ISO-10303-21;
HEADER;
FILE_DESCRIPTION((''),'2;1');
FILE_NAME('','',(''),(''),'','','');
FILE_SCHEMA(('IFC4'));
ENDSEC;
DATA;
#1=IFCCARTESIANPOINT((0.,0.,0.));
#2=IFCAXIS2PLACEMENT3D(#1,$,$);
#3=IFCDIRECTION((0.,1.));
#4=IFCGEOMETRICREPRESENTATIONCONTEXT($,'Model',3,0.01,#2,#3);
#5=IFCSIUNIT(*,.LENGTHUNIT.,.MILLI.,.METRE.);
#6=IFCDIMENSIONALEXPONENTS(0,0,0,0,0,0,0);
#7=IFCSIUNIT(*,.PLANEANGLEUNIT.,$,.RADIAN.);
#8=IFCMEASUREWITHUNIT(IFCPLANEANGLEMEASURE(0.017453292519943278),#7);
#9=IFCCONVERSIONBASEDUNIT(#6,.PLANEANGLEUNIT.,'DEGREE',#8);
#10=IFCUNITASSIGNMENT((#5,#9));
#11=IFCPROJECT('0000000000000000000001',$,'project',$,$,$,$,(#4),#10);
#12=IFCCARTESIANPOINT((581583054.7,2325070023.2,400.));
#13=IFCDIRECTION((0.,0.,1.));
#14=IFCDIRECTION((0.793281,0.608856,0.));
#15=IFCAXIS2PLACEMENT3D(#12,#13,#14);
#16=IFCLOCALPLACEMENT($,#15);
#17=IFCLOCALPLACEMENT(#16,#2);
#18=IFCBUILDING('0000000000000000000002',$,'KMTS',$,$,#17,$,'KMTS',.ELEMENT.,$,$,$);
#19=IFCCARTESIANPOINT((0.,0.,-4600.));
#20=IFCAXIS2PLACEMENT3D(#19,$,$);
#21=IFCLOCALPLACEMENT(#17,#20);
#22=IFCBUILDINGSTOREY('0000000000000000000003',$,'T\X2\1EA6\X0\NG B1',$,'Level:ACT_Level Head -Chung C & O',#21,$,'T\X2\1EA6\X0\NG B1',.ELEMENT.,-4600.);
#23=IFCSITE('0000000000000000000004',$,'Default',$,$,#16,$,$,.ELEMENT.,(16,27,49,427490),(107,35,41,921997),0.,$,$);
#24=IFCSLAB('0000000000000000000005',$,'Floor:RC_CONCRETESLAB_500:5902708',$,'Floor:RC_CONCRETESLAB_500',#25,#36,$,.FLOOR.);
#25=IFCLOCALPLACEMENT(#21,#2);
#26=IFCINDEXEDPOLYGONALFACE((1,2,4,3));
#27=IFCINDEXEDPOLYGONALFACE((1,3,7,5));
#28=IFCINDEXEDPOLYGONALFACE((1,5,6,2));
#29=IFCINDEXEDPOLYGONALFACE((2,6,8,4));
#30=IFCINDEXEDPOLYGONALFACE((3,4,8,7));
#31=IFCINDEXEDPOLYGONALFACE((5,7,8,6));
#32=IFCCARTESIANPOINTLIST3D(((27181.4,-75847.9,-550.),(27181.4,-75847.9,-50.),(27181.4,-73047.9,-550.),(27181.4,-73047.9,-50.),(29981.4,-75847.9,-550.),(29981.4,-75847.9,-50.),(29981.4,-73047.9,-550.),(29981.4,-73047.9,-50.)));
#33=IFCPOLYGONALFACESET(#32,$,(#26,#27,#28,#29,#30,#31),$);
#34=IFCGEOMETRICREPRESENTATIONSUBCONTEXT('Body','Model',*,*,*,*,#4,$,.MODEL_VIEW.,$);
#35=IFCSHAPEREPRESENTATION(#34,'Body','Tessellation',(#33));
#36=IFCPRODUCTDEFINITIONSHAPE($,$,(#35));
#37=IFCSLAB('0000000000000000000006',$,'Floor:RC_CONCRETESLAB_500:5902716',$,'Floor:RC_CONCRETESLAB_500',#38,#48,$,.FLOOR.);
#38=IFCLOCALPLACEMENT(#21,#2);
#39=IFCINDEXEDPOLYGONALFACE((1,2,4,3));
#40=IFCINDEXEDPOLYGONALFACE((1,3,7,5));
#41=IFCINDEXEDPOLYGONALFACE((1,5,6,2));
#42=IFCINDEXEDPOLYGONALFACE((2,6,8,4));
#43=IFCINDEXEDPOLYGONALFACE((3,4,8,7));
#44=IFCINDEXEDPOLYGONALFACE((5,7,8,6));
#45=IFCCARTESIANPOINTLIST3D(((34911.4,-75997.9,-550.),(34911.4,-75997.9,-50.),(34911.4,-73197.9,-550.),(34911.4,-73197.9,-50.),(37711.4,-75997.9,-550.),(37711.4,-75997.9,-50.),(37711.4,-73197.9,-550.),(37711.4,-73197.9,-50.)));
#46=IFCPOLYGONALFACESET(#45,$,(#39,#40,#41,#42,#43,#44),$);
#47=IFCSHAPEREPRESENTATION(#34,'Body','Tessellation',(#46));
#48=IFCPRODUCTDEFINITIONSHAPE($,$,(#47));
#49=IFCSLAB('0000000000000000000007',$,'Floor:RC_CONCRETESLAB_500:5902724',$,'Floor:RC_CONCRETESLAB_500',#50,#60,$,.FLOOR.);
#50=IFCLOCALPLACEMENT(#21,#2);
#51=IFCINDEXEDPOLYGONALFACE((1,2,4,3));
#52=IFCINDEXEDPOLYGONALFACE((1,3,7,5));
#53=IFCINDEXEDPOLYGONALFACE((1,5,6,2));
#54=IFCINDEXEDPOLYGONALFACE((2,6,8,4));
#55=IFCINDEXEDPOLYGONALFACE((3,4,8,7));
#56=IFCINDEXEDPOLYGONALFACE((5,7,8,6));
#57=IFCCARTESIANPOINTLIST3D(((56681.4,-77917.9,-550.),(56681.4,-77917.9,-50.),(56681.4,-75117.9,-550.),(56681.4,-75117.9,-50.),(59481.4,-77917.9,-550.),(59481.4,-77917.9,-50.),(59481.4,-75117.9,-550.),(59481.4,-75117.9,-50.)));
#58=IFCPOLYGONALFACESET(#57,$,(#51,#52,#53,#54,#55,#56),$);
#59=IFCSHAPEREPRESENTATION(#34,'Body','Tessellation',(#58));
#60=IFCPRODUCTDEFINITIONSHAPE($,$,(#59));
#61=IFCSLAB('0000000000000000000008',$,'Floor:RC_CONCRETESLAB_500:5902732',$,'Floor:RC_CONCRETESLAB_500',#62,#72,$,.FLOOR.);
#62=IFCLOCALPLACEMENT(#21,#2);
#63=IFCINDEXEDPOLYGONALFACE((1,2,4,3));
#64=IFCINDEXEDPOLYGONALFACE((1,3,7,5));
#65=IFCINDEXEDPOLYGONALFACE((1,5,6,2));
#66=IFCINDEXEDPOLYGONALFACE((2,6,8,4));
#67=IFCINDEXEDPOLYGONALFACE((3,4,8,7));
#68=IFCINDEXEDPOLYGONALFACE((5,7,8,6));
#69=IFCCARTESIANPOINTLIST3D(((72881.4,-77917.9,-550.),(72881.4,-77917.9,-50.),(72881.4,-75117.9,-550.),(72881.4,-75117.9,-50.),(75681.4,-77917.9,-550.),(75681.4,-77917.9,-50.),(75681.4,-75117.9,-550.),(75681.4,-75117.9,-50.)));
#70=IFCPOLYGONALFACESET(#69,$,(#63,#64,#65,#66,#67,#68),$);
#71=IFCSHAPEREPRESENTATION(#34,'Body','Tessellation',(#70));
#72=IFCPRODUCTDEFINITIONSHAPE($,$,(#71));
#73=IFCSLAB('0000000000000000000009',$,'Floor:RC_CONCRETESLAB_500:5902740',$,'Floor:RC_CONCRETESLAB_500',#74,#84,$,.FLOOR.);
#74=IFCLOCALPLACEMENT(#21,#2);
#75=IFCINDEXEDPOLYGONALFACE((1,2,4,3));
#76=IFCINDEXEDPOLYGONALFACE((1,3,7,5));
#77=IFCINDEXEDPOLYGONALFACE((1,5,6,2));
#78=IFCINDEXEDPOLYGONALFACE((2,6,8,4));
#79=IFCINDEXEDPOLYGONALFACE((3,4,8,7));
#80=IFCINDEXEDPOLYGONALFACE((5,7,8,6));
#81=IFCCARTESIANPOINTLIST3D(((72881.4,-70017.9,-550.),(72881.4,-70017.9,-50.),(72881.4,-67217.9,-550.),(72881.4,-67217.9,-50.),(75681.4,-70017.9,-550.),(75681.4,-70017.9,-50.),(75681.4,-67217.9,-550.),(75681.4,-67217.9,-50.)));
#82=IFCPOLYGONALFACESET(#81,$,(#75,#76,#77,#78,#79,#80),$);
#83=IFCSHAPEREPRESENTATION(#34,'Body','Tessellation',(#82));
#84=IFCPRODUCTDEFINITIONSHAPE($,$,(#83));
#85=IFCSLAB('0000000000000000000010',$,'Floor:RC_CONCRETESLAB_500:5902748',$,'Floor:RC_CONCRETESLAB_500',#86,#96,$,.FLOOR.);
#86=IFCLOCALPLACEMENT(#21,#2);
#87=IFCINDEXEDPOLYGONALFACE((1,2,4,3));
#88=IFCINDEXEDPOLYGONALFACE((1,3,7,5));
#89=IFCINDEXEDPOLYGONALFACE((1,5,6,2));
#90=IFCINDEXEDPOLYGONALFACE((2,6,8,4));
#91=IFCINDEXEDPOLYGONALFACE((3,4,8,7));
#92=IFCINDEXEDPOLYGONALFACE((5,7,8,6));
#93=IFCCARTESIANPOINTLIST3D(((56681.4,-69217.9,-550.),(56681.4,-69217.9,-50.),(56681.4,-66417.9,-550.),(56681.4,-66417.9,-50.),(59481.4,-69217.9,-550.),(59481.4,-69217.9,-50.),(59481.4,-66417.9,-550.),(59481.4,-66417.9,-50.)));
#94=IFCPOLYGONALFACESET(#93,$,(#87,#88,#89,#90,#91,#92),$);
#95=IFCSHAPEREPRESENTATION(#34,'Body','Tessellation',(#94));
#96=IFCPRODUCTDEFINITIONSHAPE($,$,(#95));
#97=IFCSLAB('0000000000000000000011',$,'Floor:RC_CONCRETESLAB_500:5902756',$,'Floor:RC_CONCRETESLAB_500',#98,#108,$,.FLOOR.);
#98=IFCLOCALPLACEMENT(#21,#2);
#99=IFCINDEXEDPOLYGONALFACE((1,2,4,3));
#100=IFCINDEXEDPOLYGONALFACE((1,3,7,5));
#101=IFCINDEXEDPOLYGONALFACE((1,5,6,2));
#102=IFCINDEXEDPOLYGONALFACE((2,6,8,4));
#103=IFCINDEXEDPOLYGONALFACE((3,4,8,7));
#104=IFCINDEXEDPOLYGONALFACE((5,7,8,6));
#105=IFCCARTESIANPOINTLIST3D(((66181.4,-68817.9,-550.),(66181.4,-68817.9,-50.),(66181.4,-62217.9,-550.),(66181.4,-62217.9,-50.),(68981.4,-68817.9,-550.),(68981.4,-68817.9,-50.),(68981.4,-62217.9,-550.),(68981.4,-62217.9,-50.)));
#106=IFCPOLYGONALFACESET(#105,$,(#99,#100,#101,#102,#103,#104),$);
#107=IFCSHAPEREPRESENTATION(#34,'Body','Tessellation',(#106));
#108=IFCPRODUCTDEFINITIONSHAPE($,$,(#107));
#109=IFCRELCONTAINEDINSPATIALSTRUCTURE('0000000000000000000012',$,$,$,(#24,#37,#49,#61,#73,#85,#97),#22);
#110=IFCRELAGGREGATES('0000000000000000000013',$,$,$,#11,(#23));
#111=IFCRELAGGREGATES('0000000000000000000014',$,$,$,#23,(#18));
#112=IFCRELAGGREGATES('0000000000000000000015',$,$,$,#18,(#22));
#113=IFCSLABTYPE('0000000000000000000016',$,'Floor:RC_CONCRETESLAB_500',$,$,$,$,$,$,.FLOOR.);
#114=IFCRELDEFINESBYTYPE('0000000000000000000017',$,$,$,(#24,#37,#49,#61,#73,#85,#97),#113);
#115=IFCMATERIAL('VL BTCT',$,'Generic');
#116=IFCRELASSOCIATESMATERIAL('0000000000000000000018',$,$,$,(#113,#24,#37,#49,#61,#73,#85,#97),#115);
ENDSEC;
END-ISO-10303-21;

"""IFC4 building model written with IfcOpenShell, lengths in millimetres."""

from ifc_helpers import new_model, entity, si_unit, converted_unit, direction, frame, origin, place, context, subcontext, project, spatial, indexed_curve, outline, extrude, material, type_object, element, save


model = new_model("IFC4")

# Units and contexts
model_context = context("Model", 3, precision=0.01, world=origin(), true_north=direction((0.0, 1.0)))
body_context = subcontext(model_context, "Body", "Model", "MODEL_VIEW")
ifc_project = project(units=[si_unit("LENGTHUNIT", "METRE", prefix="MILLI"), converted_unit("PLANEANGLEUNIT", "DEGREE", entity("IfcPlaneAngleMeasure", 0.017453292519943278), si_unit("PLANEANGLEUNIT", "RADIAN"), dimensions=[0, 0, 0, 0, 0, 0, 0])], contexts=[model_context])

# Site, building, storey
site_placement = place(None, frame((581583054.7, 2325070023.2, 400.0), z_axis=(0.0, 0.0, 1.0), x_axis=(0.793281, 0.608856, 0.0)))
site = spatial("IfcSite", under=ifc_project, at=site_placement, Name="Default", CompositionType="ELEMENT", RefLatitude=(16, 27, 49, 427490), RefLongitude=(107, 35, 41, 921997), RefElevation=0.0)
building_placement = place(site_placement, origin())
building = spatial("IfcBuilding", under=site, at=building_placement, Name="KMTS", LongName="KMTS", CompositionType="ELEMENT")
storey_placement = place(building_placement, frame((0.0, 0.0, -4600.0)))
storey = spatial("IfcBuildingStorey", under=building, at=storey_placement, Name="TẦNG B1", ObjectType="Level:ACT_Level Head -Chung C & O", LongName="TẦNG B1", CompositionType="ELEMENT", Elevation=-4600.0)

# Slabs
ifc_material = material(Name="VL BTCT", Category="Generic")
slab_type = type_object("IfcSlabType", Name="Floor:RC_CONCRETESLAB_500", PredefinedType="FLOOR", material=ifc_material)
slab_1_placement = place(storey_placement, origin())
element("IfcSlab", 1, at=slab_1_placement, inside=storey, type_object=slab_type, material=ifc_material, Name="Floor:RC_CONCRETESLAB_500:5902708", ObjectType="Floor:RC_CONCRETESLAB_500", PredefinedType="FLOOR", context=body_context, shape_type="SweptSolid", body=[
    extrude(outline(indexed_curve([(-1400.0, -1400.0), (1400.0, -1400.0), (1400.0, 1400.0), (-1400.0, 1400.0), (-1400.0, -1400.0)], self_intersect=False)), frame((28581.4, -74447.9, -50.0), z_axis=(0.0, 0.0, -1.0), x_axis=(0.0, 1.0, 0.0)), (0.0, 0.0, 1.0), 500.0),
])
slab_2_placement = place(storey_placement, origin())
element("IfcSlab", 2, at=slab_2_placement, inside=storey, type_object=slab_type, material=ifc_material, Name="Floor:RC_CONCRETESLAB_500:5902716", ObjectType="Floor:RC_CONCRETESLAB_500", PredefinedType="FLOOR", context=body_context, shape_type="SweptSolid", body=[
    extrude(outline(indexed_curve([(-1400.0, -1400.0), (1400.0, -1400.0), (1400.0, 1400.0), (-1400.0, 1400.0), (-1400.0, -1400.0)], self_intersect=False)), frame((36311.4, -74597.9, -50.0), z_axis=(0.0, 0.0, -1.0), x_axis=(0.0, 1.0, 0.0)), (0.0, 0.0, 1.0), 500.0),
])
slab_3_placement = place(storey_placement, origin())
element("IfcSlab", 3, at=slab_3_placement, inside=storey, type_object=slab_type, material=ifc_material, Name="Floor:RC_CONCRETESLAB_500:5902724", ObjectType="Floor:RC_CONCRETESLAB_500", PredefinedType="FLOOR", context=body_context, shape_type="SweptSolid", body=[
    extrude(outline(indexed_curve([(-1400.0, -1400.0), (1400.0, -1400.0), (1400.0, 1400.0), (-1400.0, 1400.0), (-1400.0, -1400.0)], self_intersect=False)), frame((58081.4, -76517.9, -50.0), z_axis=(0.0, 0.0, -1.0), x_axis=(0.0, 1.0, 0.0)), (0.0, 0.0, 1.0), 500.0),
])
slab_4_placement = place(storey_placement, origin())
element("IfcSlab", 4, at=slab_4_placement, inside=storey, type_object=slab_type, material=ifc_material, Name="Floor:RC_CONCRETESLAB_500:5902732", ObjectType="Floor:RC_CONCRETESLAB_500", PredefinedType="FLOOR", context=body_context, shape_type="SweptSolid", body=[
    extrude(outline(indexed_curve([(-1400.0, -1400.0), (1400.0, -1400.0), (1400.0, 1400.0), (-1400.0, 1400.0), (-1400.0, -1400.0)], self_intersect=False)), frame((74281.4, -76517.9, -50.0), z_axis=(0.0, 0.0, -1.0), x_axis=(0.0, 1.0, 0.0)), (0.0, 0.0, 1.0), 500.0),
])
slab_5_placement = place(storey_placement, origin())
element("IfcSlab", 5, at=slab_5_placement, inside=storey, type_object=slab_type, material=ifc_material, Name="Floor:RC_CONCRETESLAB_500:5902740", ObjectType="Floor:RC_CONCRETESLAB_500", PredefinedType="FLOOR", context=body_context, shape_type="SweptSolid", body=[
    extrude(outline(indexed_curve([(-1400.0, -1400.0), (1400.0, -1400.0), (1400.0, 1400.0), (-1400.0, 1400.0), (-1400.0, -1400.0)], self_intersect=False)), frame((74281.4, -68617.9, -50.0), z_axis=(0.0, 0.0, -1.0), x_axis=(0.0, 1.0, 0.0)), (0.0, 0.0, 1.0), 500.0),
])
slab_6_placement = place(storey_placement, origin())
element("IfcSlab", 6, at=slab_6_placement, inside=storey, type_object=slab_type, material=ifc_material, Name="Floor:RC_CONCRETESLAB_500:5902748", ObjectType="Floor:RC_CONCRETESLAB_500", PredefinedType="FLOOR", context=body_context, shape_type="SweptSolid", body=[
    extrude(outline(indexed_curve([(-1400.0, -1400.0), (1400.0, -1400.0), (1400.0, 1400.0), (-1400.0, 1400.0), (-1400.0, -1400.0)], self_intersect=False)), frame((58081.4, -67817.9, -50.0), z_axis=(0.0, 0.0, -1.0), x_axis=(0.0, 1.0, 0.0)), (0.0, 0.0, 1.0), 500.0),
])
slab_7_placement = place(storey_placement, origin())
element("IfcSlab", 7, at=slab_7_placement, inside=storey, type_object=slab_type, material=ifc_material, Name="Floor:RC_CONCRETESLAB_500:5902756", ObjectType="Floor:RC_CONCRETESLAB_500", PredefinedType="FLOOR", context=body_context, shape_type="SweptSolid", body=[
    extrude(outline(indexed_curve([(-3300.0, -1400.0), (3300.0, -1400.0), (3300.0, 1400.0), (-3300.0, 1400.0), (-3300.0, -1400.0)], self_intersect=False)), frame((67581.4, -65517.9, -50.0), z_axis=(0.0, 0.0, -1.0), x_axis=(0.0, 1.0, 0.0)), (0.0, 0.0, 1.0), 500.0),
])

save(model, "model.ifc")
